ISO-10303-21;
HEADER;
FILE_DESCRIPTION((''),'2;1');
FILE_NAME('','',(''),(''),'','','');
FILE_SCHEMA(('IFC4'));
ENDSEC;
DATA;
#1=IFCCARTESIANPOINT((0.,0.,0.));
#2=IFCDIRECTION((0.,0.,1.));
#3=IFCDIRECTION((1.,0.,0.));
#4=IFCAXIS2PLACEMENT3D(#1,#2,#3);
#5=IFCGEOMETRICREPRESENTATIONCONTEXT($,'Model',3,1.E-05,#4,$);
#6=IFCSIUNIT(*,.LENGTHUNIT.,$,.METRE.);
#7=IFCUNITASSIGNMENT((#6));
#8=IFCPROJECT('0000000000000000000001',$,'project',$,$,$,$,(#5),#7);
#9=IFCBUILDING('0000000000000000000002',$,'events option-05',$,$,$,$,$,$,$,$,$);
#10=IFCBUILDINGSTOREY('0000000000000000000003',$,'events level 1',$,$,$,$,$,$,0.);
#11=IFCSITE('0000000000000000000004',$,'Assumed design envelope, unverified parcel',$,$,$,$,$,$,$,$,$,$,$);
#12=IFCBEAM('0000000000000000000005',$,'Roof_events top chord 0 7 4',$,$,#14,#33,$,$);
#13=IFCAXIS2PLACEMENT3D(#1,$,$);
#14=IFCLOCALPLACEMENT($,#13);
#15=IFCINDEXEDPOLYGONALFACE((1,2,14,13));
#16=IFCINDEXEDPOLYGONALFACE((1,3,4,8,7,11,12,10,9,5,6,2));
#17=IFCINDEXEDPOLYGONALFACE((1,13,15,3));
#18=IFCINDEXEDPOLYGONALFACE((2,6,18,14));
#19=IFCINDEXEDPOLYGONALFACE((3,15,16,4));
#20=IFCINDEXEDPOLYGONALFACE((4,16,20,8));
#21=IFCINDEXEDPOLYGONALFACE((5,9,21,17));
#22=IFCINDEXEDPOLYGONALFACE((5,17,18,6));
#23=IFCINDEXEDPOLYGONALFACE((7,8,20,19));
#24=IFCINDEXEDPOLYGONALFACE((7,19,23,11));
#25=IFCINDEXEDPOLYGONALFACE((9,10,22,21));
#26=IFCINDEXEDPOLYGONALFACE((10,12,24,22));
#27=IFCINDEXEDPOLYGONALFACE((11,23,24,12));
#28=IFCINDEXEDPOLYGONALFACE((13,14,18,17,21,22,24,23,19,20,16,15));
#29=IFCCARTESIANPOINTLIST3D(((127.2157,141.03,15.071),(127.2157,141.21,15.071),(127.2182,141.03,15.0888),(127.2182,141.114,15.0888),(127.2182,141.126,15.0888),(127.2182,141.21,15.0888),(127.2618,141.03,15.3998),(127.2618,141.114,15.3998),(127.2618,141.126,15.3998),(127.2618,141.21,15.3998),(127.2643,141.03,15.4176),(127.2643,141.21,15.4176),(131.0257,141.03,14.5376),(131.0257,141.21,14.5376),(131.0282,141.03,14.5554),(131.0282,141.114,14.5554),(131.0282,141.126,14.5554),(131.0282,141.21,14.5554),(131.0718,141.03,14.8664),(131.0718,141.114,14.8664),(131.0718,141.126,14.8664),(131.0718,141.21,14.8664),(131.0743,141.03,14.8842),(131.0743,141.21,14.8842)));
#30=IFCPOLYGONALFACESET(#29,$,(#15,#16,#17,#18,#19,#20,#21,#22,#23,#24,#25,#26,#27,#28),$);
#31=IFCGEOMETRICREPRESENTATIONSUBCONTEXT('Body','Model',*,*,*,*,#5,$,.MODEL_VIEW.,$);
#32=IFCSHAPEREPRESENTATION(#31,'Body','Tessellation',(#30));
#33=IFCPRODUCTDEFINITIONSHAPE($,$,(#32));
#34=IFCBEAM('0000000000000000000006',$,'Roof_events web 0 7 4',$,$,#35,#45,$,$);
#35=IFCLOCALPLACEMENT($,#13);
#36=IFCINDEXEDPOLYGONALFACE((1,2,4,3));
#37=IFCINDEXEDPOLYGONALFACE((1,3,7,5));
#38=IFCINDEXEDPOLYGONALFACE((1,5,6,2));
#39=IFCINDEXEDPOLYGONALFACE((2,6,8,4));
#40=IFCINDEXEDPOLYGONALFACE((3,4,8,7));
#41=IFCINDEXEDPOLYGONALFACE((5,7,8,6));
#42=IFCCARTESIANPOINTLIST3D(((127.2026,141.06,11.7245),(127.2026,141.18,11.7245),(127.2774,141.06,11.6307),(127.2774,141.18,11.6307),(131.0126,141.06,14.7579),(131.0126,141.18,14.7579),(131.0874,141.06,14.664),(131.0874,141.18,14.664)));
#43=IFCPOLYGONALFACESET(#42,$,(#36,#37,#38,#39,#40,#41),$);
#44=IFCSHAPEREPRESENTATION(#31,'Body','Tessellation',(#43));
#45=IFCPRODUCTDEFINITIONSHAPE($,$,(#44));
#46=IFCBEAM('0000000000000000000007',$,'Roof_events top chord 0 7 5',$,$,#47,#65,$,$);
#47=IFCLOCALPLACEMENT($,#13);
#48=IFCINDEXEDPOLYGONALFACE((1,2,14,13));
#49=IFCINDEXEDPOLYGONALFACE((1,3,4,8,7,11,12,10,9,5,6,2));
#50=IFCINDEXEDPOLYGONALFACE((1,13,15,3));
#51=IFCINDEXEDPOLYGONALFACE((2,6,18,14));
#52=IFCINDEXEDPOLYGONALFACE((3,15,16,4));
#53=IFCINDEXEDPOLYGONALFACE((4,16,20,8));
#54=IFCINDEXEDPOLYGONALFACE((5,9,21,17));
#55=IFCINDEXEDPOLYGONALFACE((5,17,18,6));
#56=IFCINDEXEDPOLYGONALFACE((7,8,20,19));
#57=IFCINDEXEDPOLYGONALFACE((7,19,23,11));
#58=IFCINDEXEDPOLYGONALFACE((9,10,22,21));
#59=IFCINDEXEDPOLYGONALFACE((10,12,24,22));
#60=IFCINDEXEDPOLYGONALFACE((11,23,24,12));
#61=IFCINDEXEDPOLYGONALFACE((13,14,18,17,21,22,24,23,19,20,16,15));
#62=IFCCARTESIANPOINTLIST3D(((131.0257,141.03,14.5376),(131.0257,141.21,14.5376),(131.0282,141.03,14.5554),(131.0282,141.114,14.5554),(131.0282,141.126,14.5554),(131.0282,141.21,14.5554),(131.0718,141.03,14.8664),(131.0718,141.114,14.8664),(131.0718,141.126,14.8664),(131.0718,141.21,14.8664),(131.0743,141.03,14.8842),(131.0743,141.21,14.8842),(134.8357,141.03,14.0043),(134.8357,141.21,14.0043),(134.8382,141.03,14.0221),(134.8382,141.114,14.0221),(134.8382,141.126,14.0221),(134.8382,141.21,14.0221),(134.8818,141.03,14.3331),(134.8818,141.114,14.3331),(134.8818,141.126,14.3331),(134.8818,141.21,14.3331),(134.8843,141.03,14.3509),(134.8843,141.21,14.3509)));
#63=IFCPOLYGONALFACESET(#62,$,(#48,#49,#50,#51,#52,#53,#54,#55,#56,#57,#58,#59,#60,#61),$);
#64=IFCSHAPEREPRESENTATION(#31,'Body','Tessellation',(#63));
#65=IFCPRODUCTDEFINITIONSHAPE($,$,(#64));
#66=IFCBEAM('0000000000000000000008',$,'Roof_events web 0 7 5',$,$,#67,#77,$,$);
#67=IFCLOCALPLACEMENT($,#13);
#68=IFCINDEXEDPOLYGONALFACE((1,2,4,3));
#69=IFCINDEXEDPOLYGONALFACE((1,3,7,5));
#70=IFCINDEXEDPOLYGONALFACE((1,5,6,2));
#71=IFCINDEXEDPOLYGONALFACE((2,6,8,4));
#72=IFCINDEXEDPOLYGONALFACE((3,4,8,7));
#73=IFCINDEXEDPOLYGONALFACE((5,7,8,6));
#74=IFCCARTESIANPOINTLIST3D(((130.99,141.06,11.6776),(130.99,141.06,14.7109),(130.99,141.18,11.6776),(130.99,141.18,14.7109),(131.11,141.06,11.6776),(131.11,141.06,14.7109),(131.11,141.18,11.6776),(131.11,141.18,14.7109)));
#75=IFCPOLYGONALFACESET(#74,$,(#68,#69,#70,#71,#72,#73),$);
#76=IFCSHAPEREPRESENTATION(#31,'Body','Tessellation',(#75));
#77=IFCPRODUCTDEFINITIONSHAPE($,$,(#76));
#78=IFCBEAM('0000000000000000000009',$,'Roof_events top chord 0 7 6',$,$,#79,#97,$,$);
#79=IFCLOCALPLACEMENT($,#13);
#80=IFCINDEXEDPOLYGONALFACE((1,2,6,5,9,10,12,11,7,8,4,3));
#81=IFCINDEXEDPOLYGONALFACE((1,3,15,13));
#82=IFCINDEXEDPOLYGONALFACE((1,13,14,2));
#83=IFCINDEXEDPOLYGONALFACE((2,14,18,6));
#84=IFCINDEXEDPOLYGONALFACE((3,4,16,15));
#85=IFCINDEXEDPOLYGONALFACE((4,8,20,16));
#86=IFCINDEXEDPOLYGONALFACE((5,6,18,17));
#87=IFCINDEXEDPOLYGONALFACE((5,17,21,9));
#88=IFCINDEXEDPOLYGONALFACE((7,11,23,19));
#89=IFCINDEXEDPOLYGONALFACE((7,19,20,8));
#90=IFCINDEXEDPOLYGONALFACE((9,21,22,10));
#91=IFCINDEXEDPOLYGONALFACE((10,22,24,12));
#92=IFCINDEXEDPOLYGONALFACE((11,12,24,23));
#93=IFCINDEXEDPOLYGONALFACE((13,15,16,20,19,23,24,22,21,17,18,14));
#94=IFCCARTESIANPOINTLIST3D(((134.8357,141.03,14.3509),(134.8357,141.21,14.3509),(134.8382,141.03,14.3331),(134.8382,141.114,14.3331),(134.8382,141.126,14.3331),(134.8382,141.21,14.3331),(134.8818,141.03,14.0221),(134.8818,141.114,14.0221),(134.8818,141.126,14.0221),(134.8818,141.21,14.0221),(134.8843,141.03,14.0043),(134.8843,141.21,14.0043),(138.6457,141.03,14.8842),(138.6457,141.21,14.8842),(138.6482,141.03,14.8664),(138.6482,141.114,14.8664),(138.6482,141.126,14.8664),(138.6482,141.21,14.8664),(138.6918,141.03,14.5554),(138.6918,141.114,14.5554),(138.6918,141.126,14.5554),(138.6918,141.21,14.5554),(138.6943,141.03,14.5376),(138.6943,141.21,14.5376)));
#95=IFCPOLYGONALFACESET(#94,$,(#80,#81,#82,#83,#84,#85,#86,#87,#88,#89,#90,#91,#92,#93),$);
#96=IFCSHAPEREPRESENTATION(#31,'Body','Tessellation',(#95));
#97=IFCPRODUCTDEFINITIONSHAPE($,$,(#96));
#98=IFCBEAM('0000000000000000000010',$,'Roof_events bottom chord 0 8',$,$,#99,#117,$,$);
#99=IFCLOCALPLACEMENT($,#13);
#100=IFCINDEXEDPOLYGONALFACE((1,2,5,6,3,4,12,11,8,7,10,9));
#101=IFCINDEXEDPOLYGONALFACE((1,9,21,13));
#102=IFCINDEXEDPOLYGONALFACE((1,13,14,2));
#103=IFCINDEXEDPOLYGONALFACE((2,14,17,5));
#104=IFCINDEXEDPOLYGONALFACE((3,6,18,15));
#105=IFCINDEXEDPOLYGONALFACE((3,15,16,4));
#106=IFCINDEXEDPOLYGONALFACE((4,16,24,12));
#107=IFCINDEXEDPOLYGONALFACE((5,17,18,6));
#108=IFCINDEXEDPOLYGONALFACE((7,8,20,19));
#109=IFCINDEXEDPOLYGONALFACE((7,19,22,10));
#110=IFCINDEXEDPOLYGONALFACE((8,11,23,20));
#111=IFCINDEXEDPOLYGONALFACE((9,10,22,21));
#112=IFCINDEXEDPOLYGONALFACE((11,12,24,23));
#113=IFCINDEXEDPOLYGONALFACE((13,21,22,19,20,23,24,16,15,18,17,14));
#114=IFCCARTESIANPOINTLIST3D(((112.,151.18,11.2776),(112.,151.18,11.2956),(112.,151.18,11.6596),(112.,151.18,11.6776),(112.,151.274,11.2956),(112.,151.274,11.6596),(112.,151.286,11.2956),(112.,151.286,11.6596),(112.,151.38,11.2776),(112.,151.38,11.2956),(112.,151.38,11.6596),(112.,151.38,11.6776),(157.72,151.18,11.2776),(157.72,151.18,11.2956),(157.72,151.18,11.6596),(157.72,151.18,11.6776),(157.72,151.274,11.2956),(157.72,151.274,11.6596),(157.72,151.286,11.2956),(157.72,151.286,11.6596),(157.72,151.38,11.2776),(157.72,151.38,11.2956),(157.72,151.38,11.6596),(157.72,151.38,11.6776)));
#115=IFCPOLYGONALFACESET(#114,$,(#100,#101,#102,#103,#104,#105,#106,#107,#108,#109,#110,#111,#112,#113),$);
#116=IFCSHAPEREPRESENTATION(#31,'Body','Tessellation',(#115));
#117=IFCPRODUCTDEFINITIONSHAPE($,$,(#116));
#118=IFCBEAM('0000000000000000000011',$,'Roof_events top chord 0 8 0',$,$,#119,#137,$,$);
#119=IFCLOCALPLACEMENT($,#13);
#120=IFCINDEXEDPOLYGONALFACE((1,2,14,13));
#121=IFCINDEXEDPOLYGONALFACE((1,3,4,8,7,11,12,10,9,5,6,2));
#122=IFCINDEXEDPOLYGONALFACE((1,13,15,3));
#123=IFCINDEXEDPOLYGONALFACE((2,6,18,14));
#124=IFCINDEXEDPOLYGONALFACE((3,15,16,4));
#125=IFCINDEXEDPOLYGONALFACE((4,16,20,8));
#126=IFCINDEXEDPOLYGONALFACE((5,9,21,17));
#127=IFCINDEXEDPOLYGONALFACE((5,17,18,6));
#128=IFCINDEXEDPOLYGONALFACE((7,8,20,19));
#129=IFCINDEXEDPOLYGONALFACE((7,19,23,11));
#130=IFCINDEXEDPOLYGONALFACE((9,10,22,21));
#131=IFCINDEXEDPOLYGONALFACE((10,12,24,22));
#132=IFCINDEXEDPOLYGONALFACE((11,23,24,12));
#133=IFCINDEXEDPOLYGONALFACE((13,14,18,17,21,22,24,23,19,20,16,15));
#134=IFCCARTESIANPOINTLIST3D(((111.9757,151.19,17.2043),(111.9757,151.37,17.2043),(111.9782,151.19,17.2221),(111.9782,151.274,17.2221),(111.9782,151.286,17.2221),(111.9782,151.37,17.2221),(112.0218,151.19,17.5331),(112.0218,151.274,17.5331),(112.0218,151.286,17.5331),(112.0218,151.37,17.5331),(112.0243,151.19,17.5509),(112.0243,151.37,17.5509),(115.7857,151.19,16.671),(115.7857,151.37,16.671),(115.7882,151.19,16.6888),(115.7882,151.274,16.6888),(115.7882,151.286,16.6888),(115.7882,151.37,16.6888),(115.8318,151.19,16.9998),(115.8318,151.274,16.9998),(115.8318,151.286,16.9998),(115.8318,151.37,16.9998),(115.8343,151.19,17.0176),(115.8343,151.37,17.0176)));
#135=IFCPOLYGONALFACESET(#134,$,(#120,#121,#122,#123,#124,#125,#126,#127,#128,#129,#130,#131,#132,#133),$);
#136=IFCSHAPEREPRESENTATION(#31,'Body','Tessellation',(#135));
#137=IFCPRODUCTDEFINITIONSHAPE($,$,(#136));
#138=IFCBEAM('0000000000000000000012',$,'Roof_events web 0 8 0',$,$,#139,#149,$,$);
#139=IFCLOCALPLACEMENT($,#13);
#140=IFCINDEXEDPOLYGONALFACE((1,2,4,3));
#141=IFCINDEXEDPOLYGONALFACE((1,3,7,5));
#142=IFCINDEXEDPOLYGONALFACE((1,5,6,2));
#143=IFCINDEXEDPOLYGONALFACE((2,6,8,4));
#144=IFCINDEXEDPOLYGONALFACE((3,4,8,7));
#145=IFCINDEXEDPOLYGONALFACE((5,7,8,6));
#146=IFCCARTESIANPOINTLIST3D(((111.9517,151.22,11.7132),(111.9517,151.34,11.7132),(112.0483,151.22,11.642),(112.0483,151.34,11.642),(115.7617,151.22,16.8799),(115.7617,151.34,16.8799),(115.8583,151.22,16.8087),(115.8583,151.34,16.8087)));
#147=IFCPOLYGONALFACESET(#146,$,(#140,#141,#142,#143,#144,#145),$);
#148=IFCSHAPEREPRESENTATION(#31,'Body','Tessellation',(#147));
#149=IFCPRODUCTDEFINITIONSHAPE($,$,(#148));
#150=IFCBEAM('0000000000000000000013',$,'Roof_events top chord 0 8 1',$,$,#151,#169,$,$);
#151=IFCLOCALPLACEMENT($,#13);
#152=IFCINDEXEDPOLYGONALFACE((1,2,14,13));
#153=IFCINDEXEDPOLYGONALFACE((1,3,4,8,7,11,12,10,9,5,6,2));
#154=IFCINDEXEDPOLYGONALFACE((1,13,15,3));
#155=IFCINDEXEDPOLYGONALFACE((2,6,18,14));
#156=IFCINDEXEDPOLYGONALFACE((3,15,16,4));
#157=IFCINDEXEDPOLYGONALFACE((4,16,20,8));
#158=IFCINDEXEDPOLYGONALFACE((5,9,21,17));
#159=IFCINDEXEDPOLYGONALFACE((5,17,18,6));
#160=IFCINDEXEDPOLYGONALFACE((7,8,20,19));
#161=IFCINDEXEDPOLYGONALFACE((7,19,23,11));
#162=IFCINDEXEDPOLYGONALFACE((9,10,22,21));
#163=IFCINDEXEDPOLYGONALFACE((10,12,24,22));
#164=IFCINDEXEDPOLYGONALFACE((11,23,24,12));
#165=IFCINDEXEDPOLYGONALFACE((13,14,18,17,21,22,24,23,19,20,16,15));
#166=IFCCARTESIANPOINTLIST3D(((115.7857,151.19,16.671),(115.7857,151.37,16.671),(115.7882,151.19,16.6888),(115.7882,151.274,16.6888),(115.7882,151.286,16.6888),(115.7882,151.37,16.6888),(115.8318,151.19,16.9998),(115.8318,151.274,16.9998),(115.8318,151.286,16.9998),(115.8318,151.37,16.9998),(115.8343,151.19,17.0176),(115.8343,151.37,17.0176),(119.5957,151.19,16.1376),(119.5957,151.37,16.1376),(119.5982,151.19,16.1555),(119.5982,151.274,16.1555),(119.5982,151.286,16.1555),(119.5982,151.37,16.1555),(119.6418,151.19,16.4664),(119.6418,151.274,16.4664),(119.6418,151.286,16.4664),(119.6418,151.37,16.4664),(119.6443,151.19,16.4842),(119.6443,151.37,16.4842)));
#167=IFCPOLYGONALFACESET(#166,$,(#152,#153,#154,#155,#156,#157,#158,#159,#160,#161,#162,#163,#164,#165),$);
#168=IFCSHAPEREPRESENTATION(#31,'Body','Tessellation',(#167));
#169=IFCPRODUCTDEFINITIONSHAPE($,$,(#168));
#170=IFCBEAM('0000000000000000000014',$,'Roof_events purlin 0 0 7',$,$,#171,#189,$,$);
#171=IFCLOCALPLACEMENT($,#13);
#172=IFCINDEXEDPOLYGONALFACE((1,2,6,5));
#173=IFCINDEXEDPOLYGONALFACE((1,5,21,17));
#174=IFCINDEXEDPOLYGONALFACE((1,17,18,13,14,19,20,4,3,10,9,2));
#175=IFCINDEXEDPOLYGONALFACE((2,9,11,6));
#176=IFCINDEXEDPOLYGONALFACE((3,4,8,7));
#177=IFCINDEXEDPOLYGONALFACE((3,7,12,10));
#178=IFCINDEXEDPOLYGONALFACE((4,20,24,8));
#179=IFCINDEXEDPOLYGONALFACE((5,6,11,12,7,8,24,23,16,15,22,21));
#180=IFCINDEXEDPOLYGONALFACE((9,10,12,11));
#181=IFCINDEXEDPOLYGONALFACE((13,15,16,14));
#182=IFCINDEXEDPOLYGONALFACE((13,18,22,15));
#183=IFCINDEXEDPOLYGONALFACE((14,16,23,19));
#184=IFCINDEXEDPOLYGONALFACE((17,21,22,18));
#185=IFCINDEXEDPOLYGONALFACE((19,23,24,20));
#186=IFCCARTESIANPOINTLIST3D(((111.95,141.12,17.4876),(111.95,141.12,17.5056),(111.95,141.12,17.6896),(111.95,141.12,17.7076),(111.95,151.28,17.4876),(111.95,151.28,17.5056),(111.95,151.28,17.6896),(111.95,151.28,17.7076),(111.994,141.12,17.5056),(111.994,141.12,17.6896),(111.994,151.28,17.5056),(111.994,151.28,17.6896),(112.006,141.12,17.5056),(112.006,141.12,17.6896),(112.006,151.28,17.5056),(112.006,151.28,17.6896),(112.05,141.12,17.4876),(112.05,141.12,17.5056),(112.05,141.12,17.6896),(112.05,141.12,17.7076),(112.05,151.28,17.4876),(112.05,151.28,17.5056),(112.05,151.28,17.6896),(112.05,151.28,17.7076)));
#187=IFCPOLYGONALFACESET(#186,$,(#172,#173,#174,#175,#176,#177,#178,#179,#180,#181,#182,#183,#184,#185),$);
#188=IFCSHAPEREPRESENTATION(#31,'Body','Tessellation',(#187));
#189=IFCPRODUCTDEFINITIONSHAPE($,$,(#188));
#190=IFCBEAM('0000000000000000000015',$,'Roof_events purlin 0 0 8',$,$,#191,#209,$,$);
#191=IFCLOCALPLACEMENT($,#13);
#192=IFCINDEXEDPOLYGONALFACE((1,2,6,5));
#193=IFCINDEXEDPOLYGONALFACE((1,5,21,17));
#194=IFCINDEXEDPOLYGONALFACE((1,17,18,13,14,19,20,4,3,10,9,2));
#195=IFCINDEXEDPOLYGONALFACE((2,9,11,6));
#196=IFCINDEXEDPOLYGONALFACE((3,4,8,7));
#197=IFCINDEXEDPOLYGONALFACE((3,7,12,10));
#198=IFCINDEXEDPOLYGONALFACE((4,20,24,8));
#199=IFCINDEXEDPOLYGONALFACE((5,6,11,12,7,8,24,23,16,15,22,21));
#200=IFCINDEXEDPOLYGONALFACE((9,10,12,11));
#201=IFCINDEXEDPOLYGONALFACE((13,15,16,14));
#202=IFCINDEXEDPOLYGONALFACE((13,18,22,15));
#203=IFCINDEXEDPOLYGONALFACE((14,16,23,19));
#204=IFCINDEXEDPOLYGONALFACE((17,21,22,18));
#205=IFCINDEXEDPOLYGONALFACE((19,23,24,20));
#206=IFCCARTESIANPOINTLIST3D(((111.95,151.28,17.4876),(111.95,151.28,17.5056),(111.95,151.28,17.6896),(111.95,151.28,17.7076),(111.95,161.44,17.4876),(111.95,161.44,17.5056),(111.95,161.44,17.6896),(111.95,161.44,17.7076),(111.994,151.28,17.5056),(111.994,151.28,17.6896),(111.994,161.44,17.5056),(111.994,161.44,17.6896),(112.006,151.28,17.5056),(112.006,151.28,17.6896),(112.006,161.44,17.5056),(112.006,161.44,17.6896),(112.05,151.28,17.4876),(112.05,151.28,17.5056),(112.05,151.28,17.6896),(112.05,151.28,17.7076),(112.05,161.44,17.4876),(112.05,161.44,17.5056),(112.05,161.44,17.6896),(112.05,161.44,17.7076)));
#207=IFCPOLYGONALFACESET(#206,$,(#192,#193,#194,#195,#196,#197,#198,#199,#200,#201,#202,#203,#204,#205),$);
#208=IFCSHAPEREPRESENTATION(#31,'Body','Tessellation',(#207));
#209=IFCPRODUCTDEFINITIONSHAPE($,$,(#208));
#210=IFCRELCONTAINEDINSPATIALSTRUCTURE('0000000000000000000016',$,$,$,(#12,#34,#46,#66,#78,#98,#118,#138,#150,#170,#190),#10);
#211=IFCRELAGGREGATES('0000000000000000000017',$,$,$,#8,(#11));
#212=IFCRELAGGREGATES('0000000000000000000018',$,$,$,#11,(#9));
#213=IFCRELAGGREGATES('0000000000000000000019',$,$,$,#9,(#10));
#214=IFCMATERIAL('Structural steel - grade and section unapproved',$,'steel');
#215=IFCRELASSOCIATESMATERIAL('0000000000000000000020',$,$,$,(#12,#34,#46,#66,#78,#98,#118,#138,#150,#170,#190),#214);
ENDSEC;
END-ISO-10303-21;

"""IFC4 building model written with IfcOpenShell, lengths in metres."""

from ifc_helpers import new_model, si_unit, frame, origin_with_axes, place, context, subcontext, project, spatial, rectangle, i_section, extrude, material, element, save


model = new_model("IFC4")

# Units and contexts
model_context = context("Model", 3, precision=1e-05, world=origin_with_axes())
body_context = subcontext(model_context, "Body", "Model", "MODEL_VIEW")
ifc_project = project(units=[si_unit("LENGTHUNIT", "METRE")], contexts=[model_context])

# Site, building, storey
site = spatial("IfcSite", under=ifc_project, Name="Assumed design envelope, unverified parcel")
building = spatial("IfcBuilding", under=site, Name="events option-05")
storey = spatial("IfcBuildingStorey", under=building, Name="events level 1", Elevation=0.0)

# Shared definitions
ifc_material_1 = material(Name="Structural steel - grade and section unapproved", Category="steel")

# Beams
beam_1_placement = place(None, frame((127.24, 141.12, 15.2443), z_axis=(0.990344, 0.0, -0.138631), x_axis=(0.0, 1.0, 0.0)))
element("IfcBeam", 1, at=beam_1_placement, inside=storey, material=ifc_material_1, Name="Roof_events top chord 0 7 4", context=body_context, shape_type="SweptSolid", body=[
    extrude(i_section(OverallWidth=0.18, OverallDepth=0.35, WebThickness=0.012, FlangeThickness=0.018, FilletRadius=0.0), origin_with_axes(), (0.0, 0.0, 1.0), 3.8472),
])
beam_2_placement = place(None, frame((127.24, 141.12, 11.6776), z_axis=(0.782336, 0.0, 0.622856), x_axis=(0.0, 1.0, 0.0)))
element("IfcBeam", 2, at=beam_2_placement, inside=storey, material=ifc_material_1, Name="Roof_events web 0 7 4", context=body_context, shape_type="SweptSolid", body=[
    extrude(rectangle(XDim=0.12, YDim=0.12), origin_with_axes(), (0.0, 0.0, 1.0), 4.87),
])
beam_3_placement = place(None, frame((131.05, 141.12, 14.7109), z_axis=(0.990344, 0.0, -0.138631), x_axis=(0.0, 1.0, 0.0)))
element("IfcBeam", 3, at=beam_3_placement, inside=storey, material=ifc_material_1, Name="Roof_events top chord 0 7 5", context=body_context, shape_type="SweptSolid", body=[
    extrude(i_section(OverallWidth=0.18, OverallDepth=0.35, WebThickness=0.012, FlangeThickness=0.018, FilletRadius=0.0), origin_with_axes(), (0.0, 0.0, 1.0), 3.8471),
])
beam_4_placement = place(None, frame((131.05, 141.12, 11.6776), z_axis=(0.0, 0.0, 1.0), x_axis=(-1.0, 0.0, 0.0)))
element("IfcBeam", 4, at=beam_4_placement, inside=storey, material=ifc_material_1, Name="Roof_events web 0 7 5", context=body_context, shape_type="SweptSolid", body=[
    extrude(rectangle(XDim=0.12, YDim=0.12), origin_with_axes(), (0.0, 0.0, 1.0), 3.0333),
])
beam_5_placement = place(None, frame((134.86, 141.12, 14.1776), z_axis=(0.990344, 0.0, 0.138631), x_axis=(0.0, 1.0, 0.0)))
element("IfcBeam", 5, at=beam_5_placement, inside=storey, material=ifc_material_1, Name="Roof_events top chord 0 7 6", context=body_context, shape_type="SweptSolid", body=[
    extrude(i_section(OverallWidth=0.18, OverallDepth=0.35, WebThickness=0.012, FlangeThickness=0.018, FilletRadius=0.0), origin_with_axes(), (0.0, 0.0, 1.0), 3.8471),
])
beam_6_placement = place(None, frame((112.0, 151.28, 11.4776), z_axis=(1.0, 0.0, 0.0), x_axis=(0.0, 1.0, 0.0)))
element("IfcBeam", 6, at=beam_6_placement, inside=storey, material=ifc_material_1, Name="Roof_events bottom chord 0 8", context=body_context, shape_type="SweptSolid", body=[
    extrude(i_section(OverallWidth=0.2, OverallDepth=0.4, WebThickness=0.012, FlangeThickness=0.018, FilletRadius=0.0), origin_with_axes(), (0.0, 0.0, 1.0), 45.72),
])
beam_7_placement = place(None, frame((112.0, 151.28, 17.3776), z_axis=(0.990344, 0.0, -0.138631), x_axis=(0.0, 1.0, 0.0)))
element("IfcBeam", 7, at=beam_7_placement, inside=storey, material=ifc_material_1, Name="Roof_events top chord 0 8 0", context=body_context, shape_type="SweptSolid", body=[
    extrude(i_section(OverallWidth=0.18, OverallDepth=0.35, WebThickness=0.012, FlangeThickness=0.018, FilletRadius=0.0), origin_with_axes(), (0.0, 0.0, 1.0), 3.8471),
])
beam_8_placement = place(None, frame((112.0, 151.28, 11.6776), z_axis=(0.5935, 0.0, 0.804834), x_axis=(0.0, 1.0, 0.0)))
element("IfcBeam", 8, at=beam_8_placement, inside=storey, material=ifc_material_1, Name="Roof_events web 0 8 0", context=body_context, shape_type="SweptSolid", body=[
    extrude(rectangle(XDim=0.12, YDim=0.12), origin_with_axes(), (0.0, 0.0, 1.0), 6.4195),
])
beam_9_placement = place(None, frame((115.81, 151.28, 16.8443), z_axis=(0.990344, 0.0, -0.138631), x_axis=(0.0, 1.0, 0.0)))
element("IfcBeam", 9, at=beam_9_placement, inside=storey, material=ifc_material_1, Name="Roof_events top chord 0 8 1", context=body_context, shape_type="SweptSolid", body=[
    extrude(i_section(OverallWidth=0.18, OverallDepth=0.35, WebThickness=0.012, FlangeThickness=0.018, FilletRadius=0.0), origin_with_axes(), (0.0, 0.0, 1.0), 3.8472),
])
for number, where, z_axis, x_axis, name in (
    (10, (112.0, 141.12, 17.5976), (0.0, 1.0, 0.0), (-1.0, 0.0, 0.0), "Roof_events purlin 0 0 7"),
    (11, (112.0, 151.28, 17.5976), (0.0, 1.0, 0.0), (-1.0, 0.0, 0.0), "Roof_events purlin 0 0 8"),
):
    element("IfcBeam", number, at=place(None, frame(where, z_axis=z_axis, x_axis=x_axis)), inside=storey, material=ifc_material_1, Name=name, context=body_context, shape_type="SweptSolid", body=[
        extrude(i_section(OverallWidth=0.1, OverallDepth=0.22, WebThickness=0.012, FlangeThickness=0.018, FilletRadius=0.0), origin_with_axes(), (0.0, 0.0, 1.0), 10.16),
    ])

save(model, "model.ifc")
